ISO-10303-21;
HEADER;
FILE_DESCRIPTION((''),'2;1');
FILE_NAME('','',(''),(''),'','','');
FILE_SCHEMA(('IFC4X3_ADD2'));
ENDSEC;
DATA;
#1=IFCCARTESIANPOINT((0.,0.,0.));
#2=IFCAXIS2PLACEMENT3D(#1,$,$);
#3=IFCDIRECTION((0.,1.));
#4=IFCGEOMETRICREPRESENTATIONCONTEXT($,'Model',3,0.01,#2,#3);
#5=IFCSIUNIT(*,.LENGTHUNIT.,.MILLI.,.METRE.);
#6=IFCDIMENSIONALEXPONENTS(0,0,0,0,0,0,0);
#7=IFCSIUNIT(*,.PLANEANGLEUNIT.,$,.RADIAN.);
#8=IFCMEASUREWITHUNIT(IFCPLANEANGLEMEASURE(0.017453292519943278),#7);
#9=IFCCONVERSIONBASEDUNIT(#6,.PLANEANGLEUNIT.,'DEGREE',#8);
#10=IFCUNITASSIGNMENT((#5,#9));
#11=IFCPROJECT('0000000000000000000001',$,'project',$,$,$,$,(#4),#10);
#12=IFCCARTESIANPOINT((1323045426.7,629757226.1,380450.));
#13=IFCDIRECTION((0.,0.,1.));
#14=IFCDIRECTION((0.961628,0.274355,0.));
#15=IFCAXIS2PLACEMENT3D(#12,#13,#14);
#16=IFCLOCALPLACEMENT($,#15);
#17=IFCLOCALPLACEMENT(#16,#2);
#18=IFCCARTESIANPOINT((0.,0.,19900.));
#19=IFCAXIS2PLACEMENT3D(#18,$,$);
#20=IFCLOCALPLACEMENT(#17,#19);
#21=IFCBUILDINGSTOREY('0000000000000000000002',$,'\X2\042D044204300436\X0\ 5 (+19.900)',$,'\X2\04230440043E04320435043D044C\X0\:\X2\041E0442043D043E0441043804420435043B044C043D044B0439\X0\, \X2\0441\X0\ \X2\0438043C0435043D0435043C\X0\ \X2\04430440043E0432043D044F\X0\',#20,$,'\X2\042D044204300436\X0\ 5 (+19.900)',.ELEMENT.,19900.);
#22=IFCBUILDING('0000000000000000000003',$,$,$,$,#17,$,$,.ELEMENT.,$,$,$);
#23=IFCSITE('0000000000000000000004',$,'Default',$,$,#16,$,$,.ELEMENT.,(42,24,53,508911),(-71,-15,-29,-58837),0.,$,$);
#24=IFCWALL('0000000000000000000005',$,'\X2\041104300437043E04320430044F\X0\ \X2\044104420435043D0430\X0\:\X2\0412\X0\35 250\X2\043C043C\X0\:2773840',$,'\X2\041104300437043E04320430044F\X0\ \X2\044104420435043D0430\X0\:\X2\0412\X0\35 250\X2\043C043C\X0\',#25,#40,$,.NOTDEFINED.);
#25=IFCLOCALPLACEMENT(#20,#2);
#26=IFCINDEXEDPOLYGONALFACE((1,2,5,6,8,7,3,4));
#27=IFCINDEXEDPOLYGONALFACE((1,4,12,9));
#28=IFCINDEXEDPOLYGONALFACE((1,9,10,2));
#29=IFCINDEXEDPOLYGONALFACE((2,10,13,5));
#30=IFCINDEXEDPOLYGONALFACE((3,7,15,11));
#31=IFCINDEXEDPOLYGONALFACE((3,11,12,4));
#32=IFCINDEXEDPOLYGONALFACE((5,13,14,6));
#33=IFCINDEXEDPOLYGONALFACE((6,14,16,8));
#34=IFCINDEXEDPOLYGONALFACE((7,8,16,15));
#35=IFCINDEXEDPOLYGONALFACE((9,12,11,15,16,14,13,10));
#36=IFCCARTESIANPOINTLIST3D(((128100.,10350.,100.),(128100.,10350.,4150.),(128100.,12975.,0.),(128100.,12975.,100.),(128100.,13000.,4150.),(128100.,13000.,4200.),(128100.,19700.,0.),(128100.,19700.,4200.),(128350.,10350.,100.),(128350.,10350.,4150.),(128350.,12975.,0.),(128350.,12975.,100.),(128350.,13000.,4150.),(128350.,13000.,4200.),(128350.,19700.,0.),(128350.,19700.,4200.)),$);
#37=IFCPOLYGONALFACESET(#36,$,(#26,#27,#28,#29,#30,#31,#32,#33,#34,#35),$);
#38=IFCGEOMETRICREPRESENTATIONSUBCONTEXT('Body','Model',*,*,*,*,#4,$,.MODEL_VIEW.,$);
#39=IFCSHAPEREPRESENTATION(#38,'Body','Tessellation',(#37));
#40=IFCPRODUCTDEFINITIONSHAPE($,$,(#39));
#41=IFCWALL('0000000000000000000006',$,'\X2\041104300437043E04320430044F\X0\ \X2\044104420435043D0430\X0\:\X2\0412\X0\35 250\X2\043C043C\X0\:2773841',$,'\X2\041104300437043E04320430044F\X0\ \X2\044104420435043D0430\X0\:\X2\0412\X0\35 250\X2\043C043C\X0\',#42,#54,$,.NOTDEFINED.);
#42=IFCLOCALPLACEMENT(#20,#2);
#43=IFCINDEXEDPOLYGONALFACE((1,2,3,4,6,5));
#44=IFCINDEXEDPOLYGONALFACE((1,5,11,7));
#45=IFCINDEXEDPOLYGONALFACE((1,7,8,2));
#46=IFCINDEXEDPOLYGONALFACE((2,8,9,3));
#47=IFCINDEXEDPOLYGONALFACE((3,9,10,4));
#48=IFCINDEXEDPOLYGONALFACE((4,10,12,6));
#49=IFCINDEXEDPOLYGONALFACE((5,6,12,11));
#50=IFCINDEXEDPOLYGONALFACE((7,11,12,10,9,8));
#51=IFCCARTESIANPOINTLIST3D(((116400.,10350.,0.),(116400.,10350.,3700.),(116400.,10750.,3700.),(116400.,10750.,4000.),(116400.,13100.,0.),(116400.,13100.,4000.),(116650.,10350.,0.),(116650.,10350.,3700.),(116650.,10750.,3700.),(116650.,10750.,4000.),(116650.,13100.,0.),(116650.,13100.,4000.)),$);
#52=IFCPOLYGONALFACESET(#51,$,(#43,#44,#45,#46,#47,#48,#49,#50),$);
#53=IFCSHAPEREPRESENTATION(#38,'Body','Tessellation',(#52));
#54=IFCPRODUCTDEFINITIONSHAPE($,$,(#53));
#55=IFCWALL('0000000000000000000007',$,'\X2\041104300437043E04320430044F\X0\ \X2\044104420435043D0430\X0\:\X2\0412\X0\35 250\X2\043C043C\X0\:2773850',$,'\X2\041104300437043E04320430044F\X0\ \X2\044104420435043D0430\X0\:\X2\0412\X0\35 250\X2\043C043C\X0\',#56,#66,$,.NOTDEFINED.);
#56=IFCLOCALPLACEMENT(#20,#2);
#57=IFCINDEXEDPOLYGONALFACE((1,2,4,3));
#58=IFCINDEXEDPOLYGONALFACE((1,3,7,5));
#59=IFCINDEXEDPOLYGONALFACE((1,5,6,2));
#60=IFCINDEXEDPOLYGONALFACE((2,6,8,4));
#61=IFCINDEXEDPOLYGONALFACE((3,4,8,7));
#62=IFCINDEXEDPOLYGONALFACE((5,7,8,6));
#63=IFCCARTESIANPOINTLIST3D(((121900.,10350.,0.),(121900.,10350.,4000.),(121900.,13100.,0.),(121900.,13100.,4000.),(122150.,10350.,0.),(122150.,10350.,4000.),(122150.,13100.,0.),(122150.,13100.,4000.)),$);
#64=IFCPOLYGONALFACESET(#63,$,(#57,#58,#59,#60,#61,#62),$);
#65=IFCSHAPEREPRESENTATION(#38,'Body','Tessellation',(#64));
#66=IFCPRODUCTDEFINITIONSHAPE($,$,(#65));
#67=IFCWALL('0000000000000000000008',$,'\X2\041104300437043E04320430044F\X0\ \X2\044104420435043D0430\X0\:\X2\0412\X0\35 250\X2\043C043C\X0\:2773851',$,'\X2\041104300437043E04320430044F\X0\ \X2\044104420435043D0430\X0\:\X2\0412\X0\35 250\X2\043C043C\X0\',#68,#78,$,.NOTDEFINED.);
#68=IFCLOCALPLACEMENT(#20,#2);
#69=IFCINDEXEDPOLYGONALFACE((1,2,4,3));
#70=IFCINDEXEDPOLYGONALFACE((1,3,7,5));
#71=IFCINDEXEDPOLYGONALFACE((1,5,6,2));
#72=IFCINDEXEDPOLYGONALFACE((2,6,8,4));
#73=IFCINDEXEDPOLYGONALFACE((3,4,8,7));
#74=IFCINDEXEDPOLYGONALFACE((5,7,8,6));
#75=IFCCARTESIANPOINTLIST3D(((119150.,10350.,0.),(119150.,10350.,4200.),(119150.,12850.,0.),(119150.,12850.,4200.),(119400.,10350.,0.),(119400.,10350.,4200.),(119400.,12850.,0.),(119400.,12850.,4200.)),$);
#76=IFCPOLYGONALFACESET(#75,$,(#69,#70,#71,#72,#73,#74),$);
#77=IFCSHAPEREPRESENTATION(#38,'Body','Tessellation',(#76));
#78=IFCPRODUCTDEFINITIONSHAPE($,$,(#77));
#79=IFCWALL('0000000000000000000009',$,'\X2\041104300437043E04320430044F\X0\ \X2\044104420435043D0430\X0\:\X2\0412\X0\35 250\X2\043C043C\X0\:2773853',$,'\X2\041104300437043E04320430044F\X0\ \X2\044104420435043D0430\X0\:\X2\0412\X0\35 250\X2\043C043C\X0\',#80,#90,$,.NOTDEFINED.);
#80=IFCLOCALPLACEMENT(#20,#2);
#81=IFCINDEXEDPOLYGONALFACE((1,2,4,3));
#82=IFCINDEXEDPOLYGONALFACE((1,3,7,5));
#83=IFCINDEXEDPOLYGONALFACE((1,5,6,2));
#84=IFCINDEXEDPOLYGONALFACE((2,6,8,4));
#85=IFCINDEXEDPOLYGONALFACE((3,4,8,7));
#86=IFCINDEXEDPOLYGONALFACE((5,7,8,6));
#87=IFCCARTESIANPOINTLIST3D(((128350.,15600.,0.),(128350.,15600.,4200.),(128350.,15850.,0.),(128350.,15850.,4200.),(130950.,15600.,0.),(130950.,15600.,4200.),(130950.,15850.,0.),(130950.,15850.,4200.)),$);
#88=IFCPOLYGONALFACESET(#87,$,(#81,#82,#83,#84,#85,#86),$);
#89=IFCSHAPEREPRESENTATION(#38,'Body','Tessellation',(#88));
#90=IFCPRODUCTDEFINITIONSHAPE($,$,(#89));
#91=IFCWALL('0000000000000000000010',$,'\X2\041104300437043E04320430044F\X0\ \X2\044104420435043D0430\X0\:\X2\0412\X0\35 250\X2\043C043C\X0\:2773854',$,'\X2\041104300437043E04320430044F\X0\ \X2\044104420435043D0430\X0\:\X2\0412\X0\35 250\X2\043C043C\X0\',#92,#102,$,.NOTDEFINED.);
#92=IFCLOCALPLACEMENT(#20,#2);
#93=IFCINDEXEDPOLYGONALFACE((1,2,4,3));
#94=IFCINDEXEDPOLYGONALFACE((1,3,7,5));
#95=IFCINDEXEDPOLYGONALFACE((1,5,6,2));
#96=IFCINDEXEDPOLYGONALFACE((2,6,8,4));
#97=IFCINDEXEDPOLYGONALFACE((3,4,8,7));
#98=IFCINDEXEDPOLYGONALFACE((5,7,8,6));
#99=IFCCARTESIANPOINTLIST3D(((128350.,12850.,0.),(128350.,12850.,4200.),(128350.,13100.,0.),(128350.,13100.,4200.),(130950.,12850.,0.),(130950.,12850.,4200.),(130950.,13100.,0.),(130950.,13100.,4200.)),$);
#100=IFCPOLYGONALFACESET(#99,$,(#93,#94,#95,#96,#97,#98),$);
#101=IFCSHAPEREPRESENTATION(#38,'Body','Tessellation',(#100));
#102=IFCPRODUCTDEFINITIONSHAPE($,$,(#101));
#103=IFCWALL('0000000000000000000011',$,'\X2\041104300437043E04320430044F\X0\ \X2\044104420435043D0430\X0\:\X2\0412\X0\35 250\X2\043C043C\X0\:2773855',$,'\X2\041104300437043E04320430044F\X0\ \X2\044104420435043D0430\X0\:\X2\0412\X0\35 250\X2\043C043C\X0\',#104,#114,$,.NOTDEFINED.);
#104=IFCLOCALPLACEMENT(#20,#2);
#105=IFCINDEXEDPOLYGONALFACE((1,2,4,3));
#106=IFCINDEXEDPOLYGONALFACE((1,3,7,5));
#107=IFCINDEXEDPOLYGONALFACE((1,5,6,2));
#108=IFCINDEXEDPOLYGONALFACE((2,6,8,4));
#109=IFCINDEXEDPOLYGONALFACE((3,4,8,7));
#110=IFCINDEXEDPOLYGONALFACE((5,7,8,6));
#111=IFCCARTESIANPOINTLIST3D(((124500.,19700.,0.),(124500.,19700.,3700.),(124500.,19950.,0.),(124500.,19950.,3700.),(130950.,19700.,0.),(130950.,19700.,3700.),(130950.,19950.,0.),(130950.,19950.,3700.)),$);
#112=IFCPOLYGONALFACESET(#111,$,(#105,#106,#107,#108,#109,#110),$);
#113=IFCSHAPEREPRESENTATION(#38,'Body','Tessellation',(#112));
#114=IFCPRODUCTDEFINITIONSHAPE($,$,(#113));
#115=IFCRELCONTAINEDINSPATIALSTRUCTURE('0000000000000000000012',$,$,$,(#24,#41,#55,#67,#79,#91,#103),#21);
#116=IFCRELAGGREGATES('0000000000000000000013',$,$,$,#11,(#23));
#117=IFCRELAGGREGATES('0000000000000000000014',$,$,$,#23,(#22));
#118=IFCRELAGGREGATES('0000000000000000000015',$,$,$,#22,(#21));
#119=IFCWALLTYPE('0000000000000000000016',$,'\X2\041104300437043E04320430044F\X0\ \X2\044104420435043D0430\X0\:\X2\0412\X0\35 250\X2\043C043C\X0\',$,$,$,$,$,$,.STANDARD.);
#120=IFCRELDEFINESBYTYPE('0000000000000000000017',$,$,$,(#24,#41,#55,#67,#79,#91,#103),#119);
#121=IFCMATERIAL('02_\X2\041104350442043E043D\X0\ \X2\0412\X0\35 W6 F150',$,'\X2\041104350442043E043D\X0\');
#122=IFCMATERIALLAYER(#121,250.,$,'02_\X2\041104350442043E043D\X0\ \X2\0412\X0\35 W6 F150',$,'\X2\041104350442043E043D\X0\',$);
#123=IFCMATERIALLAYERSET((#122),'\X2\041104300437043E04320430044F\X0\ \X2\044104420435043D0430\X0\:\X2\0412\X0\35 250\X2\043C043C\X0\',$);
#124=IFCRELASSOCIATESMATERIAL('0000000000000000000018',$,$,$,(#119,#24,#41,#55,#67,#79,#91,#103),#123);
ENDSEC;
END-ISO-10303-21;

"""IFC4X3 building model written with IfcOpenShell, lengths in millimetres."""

from ifc_helpers import new_model, entity, si_unit, converted_unit, direction, frame, frame_2d, origin, place, context, subcontext, project, spatial, rectangle, extrude, material, layer, layer_set, type_object, element, save


model = new_model("IFC4X3")

# Units and contexts
model_context = context("Model", 3, precision=0.01, world=origin(), true_north=direction((0.0, 1.0)))
body_context = subcontext(model_context, "Body", "Model", "MODEL_VIEW")
ifc_project = project(units=[si_unit("LENGTHUNIT", "METRE", prefix="MILLI"), converted_unit("PLANEANGLEUNIT", "DEGREE", entity("IfcPlaneAngleMeasure", 0.017453292519943278), si_unit("PLANEANGLEUNIT", "RADIAN"), dimensions=[0, 0, 0, 0, 0, 0, 0])], contexts=[model_context])

# Site, building, storey
site_placement = place(None, frame((1323045426.7, 629757226.1, 380450.0), z_axis=(0.0, 0.0, 1.0), x_axis=(0.961628, 0.274355, 0.0)))
site = spatial("IfcSite", under=ifc_project, at=site_placement, Name="Default", CompositionType="ELEMENT", RefLatitude=(42, 24, 53, 508911), RefLongitude=(-71, -15, -29, -58837), RefElevation=0.0)
building_placement = place(site_placement, origin())
building = spatial("IfcBuilding", under=site, at=building_placement, CompositionType="ELEMENT")
storey_placement = place(building_placement, frame((0.0, 0.0, 19900.0)))
storey = spatial("IfcBuildingStorey", under=building, at=storey_placement, Name="Этаж 5 (+19.900)", ObjectType="Уровень:Относительный, с именем уровня", LongName="Этаж 5 (+19.900)", CompositionType="ELEMENT", Elevation=19900.0)

# Shared definitions
ifc_material = material(Name="02_Бетон В35 W6 F150", Category="Бетон")

# Shared definitions
ifc_layer_1 = layer(ifc_material, 250.0, Name="02_Бетон В35 W6 F150", Category="Бетон")
ifc_layer_set_1 = layer_set([ifc_layer_1], Name="Базовая стена:В35 250мм")
wall_type_1 = type_object("IfcWallType", Name="Базовая стена:В35 250мм", PredefinedType="STANDARD", material=ifc_layer_set_1)

# Wall, openings
wall_1_placement = place(storey_placement, frame((128225.0, 19700.0, 0.0), z_axis=(0.0, 0.0, 1.0), x_axis=(0.0, -1.0, 0.0)))
wall_1 = element("IfcWall", 1, at=wall_1_placement, inside=storey, type_object=wall_type_1, material=ifc_layer_set_1, Name="Базовая стена:В35 250мм:2773840", ObjectType="Базовая стена:В35 250мм", PredefinedType="NOTDEFINED", context=body_context, shape_type="SweptSolid", body=[
    extrude(rectangle(XDim=9350.0, YDim=250.0, at=frame_2d((4675.0, 0.0), x_axis=(-1.0, 0.0))), origin(), (0.0, 0.0, 1.0), 4200.0),
])
opening_1_placement = place(wall_1_placement, origin())
element("IfcOpeningElement", 2, at=opening_1_placement, cuts=wall_1, PredefinedType="OPENING", context=body_context, shape_type="SweptSolid", body=[
    extrude(rectangle(XDim=50.0, YDim=2775.0, at=frame_2d((0.0, 0.0), x_axis=(1.0, 0.0))), frame((8087.5, 125.0, 4175.0), z_axis=(0.0, -1.0, 0.0), x_axis=(0.0, 0.0, -1.0)), (0.0, 0.0, 1.0), 250.0),
])
opening_2_placement = place(wall_1_placement, origin())
element("IfcOpeningElement", 3, at=opening_2_placement, cuts=wall_1, PredefinedType="OPENING", context=body_context, shape_type="SweptSolid", body=[
    extrude(rectangle(XDim=100.0, YDim=2750.0, at=frame_2d((0.0, 0.0), x_axis=(0.0, 1.0))), frame((8100.0, 125.0, 50.0), z_axis=(0.0, -1.0, 0.0), x_axis=(-1.0, 0.0, 0.0)), (0.0, 0.0, 1.0), 250.0),
])

# Wall, opening
wall_2_placement = place(storey_placement, frame((116525.0, 10350.0, 0.0), z_axis=(0.0, 0.0, 1.0), x_axis=(0.0, 1.0, 0.0)))
wall_2 = element("IfcWall", 4, at=wall_2_placement, inside=storey, type_object=wall_type_1, material=ifc_layer_set_1, Name="Базовая стена:В35 250мм:2773841", ObjectType="Базовая стена:В35 250мм", PredefinedType="NOTDEFINED", context=body_context, shape_type="SweptSolid", body=[
    extrude(rectangle(XDim=2750.0, YDim=250.0, at=frame_2d((1375.0, 0.0), x_axis=(-1.0, 0.0))), origin(), (0.0, 0.0, 1.0), 4000.0),
])
opening_3_placement = place(wall_2_placement, origin())
element("IfcOpeningElement", 5, at=opening_3_placement, cuts=wall_2, PredefinedType="OPENING", context=body_context, shape_type="SweptSolid", body=[
    extrude(rectangle(XDim=300.0, YDim=400.0, at=frame_2d((0.0, 0.0), x_axis=(0.0, 1.0))), frame((200.0, 125.0, 3850.0), z_axis=(0.0, -1.0, 0.0), x_axis=(-1.0, 0.0, 0.0)), (0.0, 0.0, 1.0), 250.0),
])

# Walls
wall_3_placement = place(storey_placement, frame((122025.0, 13100.0, 0.0), z_axis=(0.0, 0.0, 1.0), x_axis=(0.0, -1.0, 0.0)))
element("IfcWall", 6, at=wall_3_placement, inside=storey, type_object=wall_type_1, material=ifc_layer_set_1, Name="Базовая стена:В35 250мм:2773850", ObjectType="Базовая стена:В35 250мм", PredefinedType="NOTDEFINED", context=body_context, shape_type="SweptSolid", body=[
    extrude(rectangle(XDim=2750.0, YDim=250.0, at=frame_2d((1375.0, 0.0), x_axis=(-1.0, 0.0))), origin(), (0.0, 0.0, 1.0), 4000.0),
])
wall_4_placement = place(storey_placement, frame((119275.0, 12850.0, 0.0), z_axis=(0.0, 0.0, 1.0), x_axis=(0.0, -1.0, 0.0)))
element("IfcWall", 7, at=wall_4_placement, inside=storey, type_object=wall_type_1, material=ifc_layer_set_1, Name="Базовая стена:В35 250мм:2773851", ObjectType="Базовая стена:В35 250мм", PredefinedType="NOTDEFINED", context=body_context, shape_type="SweptSolid", body=[
    extrude(rectangle(XDim=2500.0, YDim=250.0, at=frame_2d((1250.0, 0.0), x_axis=(-1.0, 0.0))), origin(), (0.0, 0.0, 1.0), 4200.0),
])
for number, where, z_axis, x_axis, name in (
    (8, (130950.0, 15725.0, 0.0), (0.0, 0.0, 1.0), (-1.0, 0.0, 0.0), "Базовая стена:В35 250мм:2773853"),
    (9, (130950.0, 12975.0, 0.0), (0.0, 0.0, 1.0), (-1.0, 0.0, 0.0), "Базовая стена:В35 250мм:2773854"),
):
    element("IfcWall", number, at=place(storey_placement, frame(where, z_axis=z_axis, x_axis=x_axis)), inside=storey, type_object=wall_type_1, material=ifc_layer_set_1, Name=name, ObjectType="Базовая стена:В35 250мм", PredefinedType="NOTDEFINED", context=body_context, shape_type="SweptSolid", body=[
        extrude(rectangle(XDim=2600.0, YDim=250.0, at=frame_2d((1300.0, 0.0), x_axis=(-1.0, 0.0))), origin(), (0.0, 0.0, 1.0), 4200.0),
    ])
wall_5_placement = place(storey_placement, frame((124500.0, 19825.0, 0.0)))
element("IfcWall", 10, at=wall_5_placement, inside=storey, type_object=wall_type_1, material=ifc_layer_set_1, Name="Базовая стена:В35 250мм:2773855", ObjectType="Базовая стена:В35 250мм", PredefinedType="NOTDEFINED", context=body_context, shape_type="SweptSolid", body=[
    extrude(rectangle(XDim=6450.0, YDim=250.0, at=frame_2d((3225.0, 0.0), x_axis=(-1.0, 0.0))), origin(), (0.0, 0.0, 1.0), 3700.0),
])

save(model, "model.ifc")
